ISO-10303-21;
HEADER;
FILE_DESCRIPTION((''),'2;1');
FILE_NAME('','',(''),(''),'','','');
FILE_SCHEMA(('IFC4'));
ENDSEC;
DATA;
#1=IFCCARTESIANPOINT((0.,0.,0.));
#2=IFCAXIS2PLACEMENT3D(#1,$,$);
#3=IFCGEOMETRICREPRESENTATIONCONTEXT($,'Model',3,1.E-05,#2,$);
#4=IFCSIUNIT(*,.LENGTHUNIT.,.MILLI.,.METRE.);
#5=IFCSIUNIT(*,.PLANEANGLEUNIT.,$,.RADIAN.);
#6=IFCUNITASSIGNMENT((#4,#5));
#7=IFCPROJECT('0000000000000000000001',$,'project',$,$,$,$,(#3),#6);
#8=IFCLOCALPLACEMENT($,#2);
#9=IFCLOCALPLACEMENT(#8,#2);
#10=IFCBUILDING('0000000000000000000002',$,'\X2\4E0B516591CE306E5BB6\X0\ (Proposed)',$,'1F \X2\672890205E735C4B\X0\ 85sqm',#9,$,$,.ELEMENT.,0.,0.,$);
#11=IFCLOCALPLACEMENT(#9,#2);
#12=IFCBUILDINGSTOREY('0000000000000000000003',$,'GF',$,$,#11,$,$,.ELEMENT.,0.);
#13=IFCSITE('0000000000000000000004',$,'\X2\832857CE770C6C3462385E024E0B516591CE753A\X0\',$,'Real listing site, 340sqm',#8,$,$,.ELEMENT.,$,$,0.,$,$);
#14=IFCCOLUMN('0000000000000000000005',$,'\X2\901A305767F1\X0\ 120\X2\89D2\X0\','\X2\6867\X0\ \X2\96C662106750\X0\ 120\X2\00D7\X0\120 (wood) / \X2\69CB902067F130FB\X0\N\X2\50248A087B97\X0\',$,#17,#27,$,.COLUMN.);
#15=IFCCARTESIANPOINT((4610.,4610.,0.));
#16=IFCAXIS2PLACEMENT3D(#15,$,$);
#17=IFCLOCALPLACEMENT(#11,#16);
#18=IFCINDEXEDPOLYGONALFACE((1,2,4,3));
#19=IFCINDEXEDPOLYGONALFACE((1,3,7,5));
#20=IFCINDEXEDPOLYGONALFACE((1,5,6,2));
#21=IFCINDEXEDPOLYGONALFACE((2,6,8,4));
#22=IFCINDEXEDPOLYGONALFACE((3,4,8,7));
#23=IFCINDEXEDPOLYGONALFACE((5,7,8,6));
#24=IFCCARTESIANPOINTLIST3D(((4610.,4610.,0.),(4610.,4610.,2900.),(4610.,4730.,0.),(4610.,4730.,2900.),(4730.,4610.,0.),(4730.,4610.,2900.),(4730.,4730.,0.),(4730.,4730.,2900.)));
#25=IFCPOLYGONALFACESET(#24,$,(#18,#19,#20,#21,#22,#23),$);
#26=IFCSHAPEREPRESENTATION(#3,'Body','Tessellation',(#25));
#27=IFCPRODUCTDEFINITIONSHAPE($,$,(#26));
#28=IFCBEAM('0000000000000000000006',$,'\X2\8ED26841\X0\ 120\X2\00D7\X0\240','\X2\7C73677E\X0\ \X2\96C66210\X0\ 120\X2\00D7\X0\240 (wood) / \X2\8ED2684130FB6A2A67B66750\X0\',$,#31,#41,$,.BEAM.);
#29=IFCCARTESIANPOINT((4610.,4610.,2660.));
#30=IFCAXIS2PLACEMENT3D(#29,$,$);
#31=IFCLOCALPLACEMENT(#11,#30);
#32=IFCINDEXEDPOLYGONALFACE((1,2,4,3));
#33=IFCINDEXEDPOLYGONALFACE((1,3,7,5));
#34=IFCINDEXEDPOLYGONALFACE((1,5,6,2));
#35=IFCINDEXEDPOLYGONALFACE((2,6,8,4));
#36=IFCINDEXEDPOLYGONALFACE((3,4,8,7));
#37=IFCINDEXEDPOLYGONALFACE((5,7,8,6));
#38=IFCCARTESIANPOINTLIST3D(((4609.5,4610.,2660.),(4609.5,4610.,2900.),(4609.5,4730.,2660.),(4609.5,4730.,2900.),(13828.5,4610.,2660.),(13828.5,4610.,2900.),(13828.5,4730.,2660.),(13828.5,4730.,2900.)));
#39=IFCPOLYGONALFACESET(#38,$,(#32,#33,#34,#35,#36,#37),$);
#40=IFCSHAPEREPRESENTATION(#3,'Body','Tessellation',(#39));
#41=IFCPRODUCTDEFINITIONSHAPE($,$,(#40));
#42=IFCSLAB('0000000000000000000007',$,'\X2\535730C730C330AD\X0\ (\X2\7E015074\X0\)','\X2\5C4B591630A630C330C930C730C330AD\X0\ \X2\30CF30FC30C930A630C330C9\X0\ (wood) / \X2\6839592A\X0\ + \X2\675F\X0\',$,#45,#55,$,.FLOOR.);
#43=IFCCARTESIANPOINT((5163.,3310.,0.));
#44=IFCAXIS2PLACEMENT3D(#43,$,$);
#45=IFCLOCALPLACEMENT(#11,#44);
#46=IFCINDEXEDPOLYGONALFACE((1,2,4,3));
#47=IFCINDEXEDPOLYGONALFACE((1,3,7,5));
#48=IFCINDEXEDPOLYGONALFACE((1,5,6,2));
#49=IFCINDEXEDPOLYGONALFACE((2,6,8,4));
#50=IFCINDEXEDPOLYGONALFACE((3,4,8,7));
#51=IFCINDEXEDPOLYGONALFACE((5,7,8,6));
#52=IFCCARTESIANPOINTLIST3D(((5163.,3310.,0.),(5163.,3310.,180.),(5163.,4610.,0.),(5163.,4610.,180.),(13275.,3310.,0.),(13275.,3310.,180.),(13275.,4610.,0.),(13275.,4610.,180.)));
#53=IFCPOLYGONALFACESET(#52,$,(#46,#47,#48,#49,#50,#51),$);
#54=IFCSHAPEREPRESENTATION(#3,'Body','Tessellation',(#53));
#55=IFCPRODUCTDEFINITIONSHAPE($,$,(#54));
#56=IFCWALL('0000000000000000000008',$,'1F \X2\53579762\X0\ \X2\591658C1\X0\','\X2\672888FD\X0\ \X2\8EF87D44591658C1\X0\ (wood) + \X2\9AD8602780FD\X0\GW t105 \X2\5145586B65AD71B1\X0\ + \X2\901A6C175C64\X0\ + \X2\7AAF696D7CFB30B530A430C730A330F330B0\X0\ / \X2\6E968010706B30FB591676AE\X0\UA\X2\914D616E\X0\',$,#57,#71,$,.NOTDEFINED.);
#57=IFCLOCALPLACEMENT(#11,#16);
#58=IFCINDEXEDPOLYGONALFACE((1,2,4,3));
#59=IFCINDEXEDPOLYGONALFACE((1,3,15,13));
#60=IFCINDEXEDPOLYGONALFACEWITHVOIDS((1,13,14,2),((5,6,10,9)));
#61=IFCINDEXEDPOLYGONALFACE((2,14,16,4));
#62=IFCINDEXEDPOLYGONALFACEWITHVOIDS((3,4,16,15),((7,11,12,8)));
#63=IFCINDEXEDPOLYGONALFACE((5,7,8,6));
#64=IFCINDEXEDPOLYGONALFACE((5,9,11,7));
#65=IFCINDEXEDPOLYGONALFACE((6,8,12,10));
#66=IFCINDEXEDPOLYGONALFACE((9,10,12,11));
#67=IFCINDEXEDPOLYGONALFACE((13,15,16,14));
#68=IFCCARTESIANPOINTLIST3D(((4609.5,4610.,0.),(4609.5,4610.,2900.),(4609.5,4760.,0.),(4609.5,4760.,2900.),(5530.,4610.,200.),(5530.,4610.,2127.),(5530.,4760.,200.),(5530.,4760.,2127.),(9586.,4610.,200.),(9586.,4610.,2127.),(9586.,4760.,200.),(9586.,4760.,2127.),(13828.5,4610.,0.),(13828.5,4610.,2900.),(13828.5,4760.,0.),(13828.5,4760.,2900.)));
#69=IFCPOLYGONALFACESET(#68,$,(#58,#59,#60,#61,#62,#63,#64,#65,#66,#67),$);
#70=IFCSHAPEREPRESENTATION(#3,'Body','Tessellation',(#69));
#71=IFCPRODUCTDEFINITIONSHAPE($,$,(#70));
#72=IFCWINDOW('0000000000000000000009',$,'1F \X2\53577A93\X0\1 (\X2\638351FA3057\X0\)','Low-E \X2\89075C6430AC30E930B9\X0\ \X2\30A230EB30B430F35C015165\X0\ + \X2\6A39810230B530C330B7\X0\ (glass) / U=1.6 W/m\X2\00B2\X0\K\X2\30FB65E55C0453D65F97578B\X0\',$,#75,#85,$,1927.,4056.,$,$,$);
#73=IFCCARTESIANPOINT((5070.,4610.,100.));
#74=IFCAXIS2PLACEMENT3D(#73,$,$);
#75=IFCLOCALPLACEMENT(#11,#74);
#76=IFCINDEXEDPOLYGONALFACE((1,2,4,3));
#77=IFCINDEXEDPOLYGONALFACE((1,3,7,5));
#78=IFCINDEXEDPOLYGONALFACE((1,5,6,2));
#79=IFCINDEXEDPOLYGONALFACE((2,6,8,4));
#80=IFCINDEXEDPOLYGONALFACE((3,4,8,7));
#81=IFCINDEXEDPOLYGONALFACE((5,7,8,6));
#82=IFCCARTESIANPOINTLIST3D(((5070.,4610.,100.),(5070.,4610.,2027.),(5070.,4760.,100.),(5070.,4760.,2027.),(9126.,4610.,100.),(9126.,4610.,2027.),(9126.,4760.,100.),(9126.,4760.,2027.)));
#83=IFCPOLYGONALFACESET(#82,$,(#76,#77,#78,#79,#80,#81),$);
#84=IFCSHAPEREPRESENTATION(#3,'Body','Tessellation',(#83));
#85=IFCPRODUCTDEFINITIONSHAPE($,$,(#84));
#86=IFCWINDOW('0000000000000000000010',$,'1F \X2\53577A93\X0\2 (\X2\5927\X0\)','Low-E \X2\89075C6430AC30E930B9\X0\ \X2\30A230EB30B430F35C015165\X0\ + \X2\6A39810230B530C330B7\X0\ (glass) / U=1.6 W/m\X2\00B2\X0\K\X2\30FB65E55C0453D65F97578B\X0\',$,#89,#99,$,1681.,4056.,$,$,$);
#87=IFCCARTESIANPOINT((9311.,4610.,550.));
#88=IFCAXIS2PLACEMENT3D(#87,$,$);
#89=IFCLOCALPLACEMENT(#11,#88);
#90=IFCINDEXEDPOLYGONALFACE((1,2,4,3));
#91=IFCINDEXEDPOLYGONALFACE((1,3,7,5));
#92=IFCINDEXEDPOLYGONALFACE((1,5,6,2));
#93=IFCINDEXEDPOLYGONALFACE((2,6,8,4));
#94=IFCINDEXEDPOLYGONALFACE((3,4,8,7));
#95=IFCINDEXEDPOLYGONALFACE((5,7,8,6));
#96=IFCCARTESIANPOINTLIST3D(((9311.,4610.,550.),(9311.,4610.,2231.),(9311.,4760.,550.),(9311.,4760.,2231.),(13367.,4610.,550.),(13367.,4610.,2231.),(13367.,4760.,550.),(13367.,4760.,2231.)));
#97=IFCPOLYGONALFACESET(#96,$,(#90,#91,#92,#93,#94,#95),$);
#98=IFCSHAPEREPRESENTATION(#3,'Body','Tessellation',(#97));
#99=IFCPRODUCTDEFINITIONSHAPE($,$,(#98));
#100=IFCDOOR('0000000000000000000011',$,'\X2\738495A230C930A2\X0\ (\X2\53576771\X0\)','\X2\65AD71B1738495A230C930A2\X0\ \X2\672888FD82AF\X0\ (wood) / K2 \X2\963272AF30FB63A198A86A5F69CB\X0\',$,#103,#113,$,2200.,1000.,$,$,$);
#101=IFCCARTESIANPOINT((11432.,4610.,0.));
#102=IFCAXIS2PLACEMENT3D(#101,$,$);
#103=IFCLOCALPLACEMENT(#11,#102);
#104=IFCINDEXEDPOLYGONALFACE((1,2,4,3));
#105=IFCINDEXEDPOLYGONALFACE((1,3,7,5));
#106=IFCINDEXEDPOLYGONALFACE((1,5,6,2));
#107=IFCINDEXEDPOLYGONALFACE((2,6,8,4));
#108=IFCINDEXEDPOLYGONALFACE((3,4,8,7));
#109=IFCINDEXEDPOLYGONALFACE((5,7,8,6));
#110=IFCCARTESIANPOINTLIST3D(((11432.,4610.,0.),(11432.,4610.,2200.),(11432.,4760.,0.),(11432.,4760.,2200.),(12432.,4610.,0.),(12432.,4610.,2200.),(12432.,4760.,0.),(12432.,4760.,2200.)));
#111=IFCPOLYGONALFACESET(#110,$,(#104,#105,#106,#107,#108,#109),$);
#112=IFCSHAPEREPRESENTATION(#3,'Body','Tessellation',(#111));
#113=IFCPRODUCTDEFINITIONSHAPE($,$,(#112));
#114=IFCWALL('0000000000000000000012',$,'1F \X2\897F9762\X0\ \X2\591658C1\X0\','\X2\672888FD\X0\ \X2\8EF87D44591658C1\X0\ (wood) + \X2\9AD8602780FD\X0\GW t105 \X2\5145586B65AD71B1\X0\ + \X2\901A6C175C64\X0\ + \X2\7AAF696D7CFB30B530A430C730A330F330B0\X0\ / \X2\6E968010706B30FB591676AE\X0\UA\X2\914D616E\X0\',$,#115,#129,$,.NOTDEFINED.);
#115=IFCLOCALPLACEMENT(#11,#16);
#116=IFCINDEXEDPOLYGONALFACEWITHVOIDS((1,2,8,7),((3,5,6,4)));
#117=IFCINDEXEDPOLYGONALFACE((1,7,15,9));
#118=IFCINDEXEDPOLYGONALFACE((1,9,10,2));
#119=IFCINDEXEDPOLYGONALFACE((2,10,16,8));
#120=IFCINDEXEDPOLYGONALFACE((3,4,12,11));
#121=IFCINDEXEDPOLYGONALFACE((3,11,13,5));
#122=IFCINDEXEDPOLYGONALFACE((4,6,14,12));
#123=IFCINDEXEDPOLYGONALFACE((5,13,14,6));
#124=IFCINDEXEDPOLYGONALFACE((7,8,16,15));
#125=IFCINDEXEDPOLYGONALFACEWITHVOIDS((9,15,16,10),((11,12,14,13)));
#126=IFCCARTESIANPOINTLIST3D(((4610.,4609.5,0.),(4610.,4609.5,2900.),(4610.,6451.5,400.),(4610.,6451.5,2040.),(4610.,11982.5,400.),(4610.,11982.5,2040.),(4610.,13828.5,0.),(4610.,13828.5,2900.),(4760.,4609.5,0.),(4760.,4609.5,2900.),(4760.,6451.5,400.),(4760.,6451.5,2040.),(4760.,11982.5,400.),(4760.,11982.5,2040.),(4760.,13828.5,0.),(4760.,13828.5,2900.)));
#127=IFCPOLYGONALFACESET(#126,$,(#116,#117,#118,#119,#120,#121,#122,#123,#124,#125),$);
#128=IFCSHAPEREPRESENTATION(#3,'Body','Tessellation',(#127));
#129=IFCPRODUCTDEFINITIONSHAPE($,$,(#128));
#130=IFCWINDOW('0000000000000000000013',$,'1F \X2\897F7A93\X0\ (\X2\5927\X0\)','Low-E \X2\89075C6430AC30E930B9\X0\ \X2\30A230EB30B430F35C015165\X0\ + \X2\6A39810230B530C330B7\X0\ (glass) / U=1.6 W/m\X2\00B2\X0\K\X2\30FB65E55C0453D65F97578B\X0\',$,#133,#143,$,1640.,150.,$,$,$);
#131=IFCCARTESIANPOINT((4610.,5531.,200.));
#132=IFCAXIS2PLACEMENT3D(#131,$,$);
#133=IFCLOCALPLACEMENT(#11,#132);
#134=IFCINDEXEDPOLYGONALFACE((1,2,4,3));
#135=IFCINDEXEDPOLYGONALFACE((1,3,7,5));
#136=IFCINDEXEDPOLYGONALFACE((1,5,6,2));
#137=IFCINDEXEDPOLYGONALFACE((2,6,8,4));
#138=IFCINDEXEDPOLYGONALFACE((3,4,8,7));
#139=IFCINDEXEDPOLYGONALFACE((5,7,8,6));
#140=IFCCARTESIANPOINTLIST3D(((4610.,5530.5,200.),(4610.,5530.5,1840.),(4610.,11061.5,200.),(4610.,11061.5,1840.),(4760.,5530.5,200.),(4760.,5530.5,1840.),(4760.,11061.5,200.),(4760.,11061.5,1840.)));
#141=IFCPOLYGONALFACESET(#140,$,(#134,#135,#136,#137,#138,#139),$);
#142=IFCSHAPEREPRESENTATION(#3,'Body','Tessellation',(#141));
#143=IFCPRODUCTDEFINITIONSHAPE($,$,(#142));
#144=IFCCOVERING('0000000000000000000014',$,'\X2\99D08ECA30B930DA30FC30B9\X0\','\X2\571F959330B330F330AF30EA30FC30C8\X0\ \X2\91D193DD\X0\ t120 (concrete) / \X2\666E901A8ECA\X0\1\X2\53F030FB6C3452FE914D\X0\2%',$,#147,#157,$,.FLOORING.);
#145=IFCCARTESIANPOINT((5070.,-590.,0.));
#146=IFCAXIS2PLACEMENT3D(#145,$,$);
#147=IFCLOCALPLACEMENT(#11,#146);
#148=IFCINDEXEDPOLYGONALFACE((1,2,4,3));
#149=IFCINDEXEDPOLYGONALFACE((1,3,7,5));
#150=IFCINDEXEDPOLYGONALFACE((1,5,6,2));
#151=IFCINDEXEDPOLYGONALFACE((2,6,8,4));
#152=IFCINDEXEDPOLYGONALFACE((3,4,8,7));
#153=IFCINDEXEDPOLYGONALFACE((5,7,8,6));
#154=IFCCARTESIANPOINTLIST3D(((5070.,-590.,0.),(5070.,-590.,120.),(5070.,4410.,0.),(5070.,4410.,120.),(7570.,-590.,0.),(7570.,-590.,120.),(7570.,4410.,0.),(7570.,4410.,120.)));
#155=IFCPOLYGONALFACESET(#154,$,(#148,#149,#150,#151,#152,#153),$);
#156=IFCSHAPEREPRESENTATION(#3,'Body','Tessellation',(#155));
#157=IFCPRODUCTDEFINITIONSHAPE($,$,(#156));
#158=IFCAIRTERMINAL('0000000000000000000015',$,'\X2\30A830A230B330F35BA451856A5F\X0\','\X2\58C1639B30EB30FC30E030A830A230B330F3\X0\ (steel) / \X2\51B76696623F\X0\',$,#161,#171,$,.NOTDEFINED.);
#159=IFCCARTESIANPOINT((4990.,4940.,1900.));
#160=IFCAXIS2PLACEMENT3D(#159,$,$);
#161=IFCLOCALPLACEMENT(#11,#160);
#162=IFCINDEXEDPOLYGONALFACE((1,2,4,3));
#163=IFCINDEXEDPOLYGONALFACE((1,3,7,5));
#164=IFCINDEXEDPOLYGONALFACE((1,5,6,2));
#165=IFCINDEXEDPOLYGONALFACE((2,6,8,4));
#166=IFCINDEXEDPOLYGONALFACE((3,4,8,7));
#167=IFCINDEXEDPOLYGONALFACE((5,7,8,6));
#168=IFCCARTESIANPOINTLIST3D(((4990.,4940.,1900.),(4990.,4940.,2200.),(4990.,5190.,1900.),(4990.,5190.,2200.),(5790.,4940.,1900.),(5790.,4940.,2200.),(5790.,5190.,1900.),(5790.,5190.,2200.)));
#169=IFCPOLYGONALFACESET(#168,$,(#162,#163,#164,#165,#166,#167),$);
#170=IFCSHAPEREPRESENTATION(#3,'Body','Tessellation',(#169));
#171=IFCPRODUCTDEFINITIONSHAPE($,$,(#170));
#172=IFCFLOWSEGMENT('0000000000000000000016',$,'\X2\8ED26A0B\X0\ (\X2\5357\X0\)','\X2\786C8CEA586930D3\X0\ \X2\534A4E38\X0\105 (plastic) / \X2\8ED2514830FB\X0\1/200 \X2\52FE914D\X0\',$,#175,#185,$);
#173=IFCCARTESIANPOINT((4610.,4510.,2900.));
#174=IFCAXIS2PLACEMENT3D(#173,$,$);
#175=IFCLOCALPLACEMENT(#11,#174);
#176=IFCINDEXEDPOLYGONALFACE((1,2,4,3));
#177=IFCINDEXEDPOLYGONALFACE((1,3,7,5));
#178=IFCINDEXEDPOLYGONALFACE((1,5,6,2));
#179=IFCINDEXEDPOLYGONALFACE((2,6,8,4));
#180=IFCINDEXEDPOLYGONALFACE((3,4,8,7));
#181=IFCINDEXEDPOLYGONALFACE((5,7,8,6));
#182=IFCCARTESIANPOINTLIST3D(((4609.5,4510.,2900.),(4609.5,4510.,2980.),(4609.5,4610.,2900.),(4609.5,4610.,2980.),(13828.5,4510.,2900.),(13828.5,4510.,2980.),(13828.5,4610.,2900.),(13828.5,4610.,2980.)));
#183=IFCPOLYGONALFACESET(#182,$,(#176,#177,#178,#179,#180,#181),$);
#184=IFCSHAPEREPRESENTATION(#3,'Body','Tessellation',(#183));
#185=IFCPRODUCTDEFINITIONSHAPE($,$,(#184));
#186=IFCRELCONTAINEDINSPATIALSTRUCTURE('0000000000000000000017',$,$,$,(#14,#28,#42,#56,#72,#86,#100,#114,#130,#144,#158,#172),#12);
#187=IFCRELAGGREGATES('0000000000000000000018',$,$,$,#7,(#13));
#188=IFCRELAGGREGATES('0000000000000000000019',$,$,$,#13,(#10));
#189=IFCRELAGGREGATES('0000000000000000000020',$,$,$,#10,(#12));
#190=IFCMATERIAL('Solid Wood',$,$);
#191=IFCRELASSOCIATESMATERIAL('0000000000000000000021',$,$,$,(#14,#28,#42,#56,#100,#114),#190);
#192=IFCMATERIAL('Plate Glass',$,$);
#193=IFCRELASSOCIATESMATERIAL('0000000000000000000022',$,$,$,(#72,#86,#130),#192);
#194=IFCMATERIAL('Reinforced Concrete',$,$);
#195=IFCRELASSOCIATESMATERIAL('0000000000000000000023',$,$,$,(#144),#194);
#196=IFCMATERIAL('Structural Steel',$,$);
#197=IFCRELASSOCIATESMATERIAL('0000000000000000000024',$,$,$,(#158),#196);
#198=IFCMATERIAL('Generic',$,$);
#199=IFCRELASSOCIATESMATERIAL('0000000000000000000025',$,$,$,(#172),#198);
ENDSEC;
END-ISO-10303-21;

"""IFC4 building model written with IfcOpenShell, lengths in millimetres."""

from ifc_helpers import new_model, si_unit, frame, frame_2d, origin, place, context, project, spatial, rectangle, extrude, material, element, fill, save


model = new_model("IFC4")

# Units and contexts
model_context = context("Model", 3, precision=1e-05, world=origin())
ifc_project = project(units=[si_unit("LENGTHUNIT", "METRE", prefix="MILLI"), si_unit("PLANEANGLEUNIT", "RADIAN")], contexts=[model_context])

# Site, building, storey
site_placement = place(None, origin())
site = spatial("IfcSite", under=ifc_project, at=site_placement, Name="茨城県水戸市下入野町", ObjectType="Real listing site, 340sqm", CompositionType="ELEMENT", RefElevation=0.0)
building_placement = place(site_placement, origin())
building = spatial("IfcBuilding", under=site, at=building_placement, Name="下入野の家 (Proposed)", ObjectType="1F 木造平屋 85sqm", CompositionType="ELEMENT", ElevationOfRefHeight=0.0, ElevationOfTerrain=0.0)
storey_placement = place(building_placement, origin())
storey = spatial("IfcBuildingStorey", under=building, at=storey_placement, Name="GF", CompositionType="ELEMENT", Elevation=0.0)

# Column
ifc_material_1 = material(Name="Solid Wood")
column_1_placement = place(storey_placement, frame((4610.0, 4610.0, 0.0)))
element("IfcColumn", 1, at=column_1_placement, inside=storey, material=ifc_material_1, Name="通し柱 120角", Description="桧 集成材 120×120 (wood) / 構造柱・N値計算", PredefinedType="COLUMN", context=model_context, shape_type="SweptSolid", body=[
    extrude(rectangle(XDim=120.0, YDim=120.0, at=frame_2d((60.0, 60.0))), frame((4610.0, 4610.0, 0.0)), (0.0, 0.0, 1.0), 2900.0),
])

# Beam
beam_1_placement = place(storey_placement, frame((4610.0, 4610.0, 2660.0)))
element("IfcBeam", 2, at=beam_1_placement, inside=storey, material=ifc_material_1, Name="軒桁 120×240", Description="米松 集成 120×240 (wood) / 軒桁・横架材", PredefinedType="BEAM", context=model_context, shape_type="SweptSolid", body=[
    extrude(rectangle(XDim=9219.0, YDim=120.0, at=frame_2d((4609.0, 60.0))), frame((4610.0, 4610.0, 2660.0)), (0.0, 0.0, 1.0), 240.0),
])

# Slab
ifc_material_2 = material(Name="Reinforced Concrete")
slab_1_placement = place(storey_placement, frame((5163.0, 3310.0, 0.0)))
element("IfcSlab", 3, at=slab_1_placement, inside=storey, material=ifc_material_1, Name="南デッキ (縁側)", Description="屋外ウッドデッキ ハードウッド (wood) / 根太 + 束", PredefinedType="FLOOR", context=model_context, shape_type="SweptSolid", body=[
    extrude(rectangle(XDim=8112.0, YDim=1300.0, at=frame_2d((4056.0, 650.0))), frame((5163.0, 3310.0, 0.0)), (0.0, 0.0, 1.0), 180.0),
])

# Wall, openings, windows, door
wall_1_placement = place(storey_placement, frame((4610.0, 4610.0, 0.0)))
wall_1 = element("IfcWall", 4, at=wall_1_placement, inside=storey, material=ifc_material_1, Name="1F 南面 外壁", Description="木製 軸組外壁 (wood) + 高性能GW t105 充填断熱 + 通気層 + 窯業系サイディング / 準耐火・外皮UA配慮", PredefinedType="NOTDEFINED", context=model_context, shape_type="SweptSolid", body=[
    extrude(rectangle(XDim=9219.0, YDim=150.0, at=frame_2d((4609.0, 75.0))), frame((4610.0, 4610.0, 0.0)), (0.0, 0.0, 1.0), 2900.0),
])
opening_1_placement = place(storey_placement, frame((5070.0, 4610.0, 100.0)))
opening_1 = element("IfcOpeningElement", 5, at=opening_1_placement, cuts=wall_1, PredefinedType="NOTDEFINED", context=model_context, shape_type="SweptSolid", body=[
    extrude(rectangle(XDim=4056.0, YDim=150.0, at=frame_2d((2028.0, 75.0))), frame((5070.0, 4610.0, 100.0)), (0.0, 0.0, 1.0), 1927.0),
])
opening_2_placement = place(storey_placement, frame((9311.0, 4610.0, 550.0)))
opening_2 = element("IfcOpeningElement", 6, at=opening_2_placement, cuts=wall_1, PredefinedType="NOTDEFINED", context=model_context, shape_type="SweptSolid", body=[
    extrude(rectangle(XDim=4056.0, YDim=150.0, at=frame_2d((2028.0, 75.0))), frame((9311.0, 4610.0, 550.0)), (0.0, 0.0, 1.0), 1681.0),
])
opening_3_placement = place(storey_placement, frame((11432.0, 4610.0, 0.0)))
opening_3 = element("IfcOpeningElement", 7, at=opening_3_placement, cuts=wall_1, PredefinedType="NOTDEFINED", context=model_context, shape_type="SweptSolid", body=[
    extrude(rectangle(XDim=1000.0, YDim=150.0, at=frame_2d((500.0, 75.0))), frame((11432.0, 4610.0, 0.0)), (0.0, 0.0, 1.0), 2200.0),
])
ifc_material_3 = material(Name="Plate Glass")
window_1_placement = place(storey_placement, frame((5070.0, 4610.0, 100.0)))
window_1 = element("IfcWindow", 8, at=window_1_placement, inside=storey, material=ifc_material_3, Name="1F 南窓1 (掃出し)", Description="Low-E 複層ガラス アルゴン封入 + 樹脂サッシ (glass) / U=1.6 W/m²K・日射取得型", OverallHeight=1927.0, OverallWidth=4056.0, context=model_context, shape_type="SweptSolid", body=[
    extrude(rectangle(XDim=4056.0, YDim=150.0, at=frame_2d((2028.0, 75.0))), frame((5070.0, 4610.0, 100.0)), (0.0, 0.0, 1.0), 1927.0),
])
fill(opening_1, window_1)
window_2_placement = place(storey_placement, frame((9311.0, 4610.0, 550.0)))
window_2 = element("IfcWindow", 9, at=window_2_placement, inside=storey, material=ifc_material_3, Name="1F 南窓2 (大)", Description="Low-E 複層ガラス アルゴン封入 + 樹脂サッシ (glass) / U=1.6 W/m²K・日射取得型", OverallHeight=1681.0, OverallWidth=4056.0, context=model_context, shape_type="SweptSolid", body=[
    extrude(rectangle(XDim=4056.0, YDim=150.0, at=frame_2d((2028.0, 75.0))), frame((9311.0, 4610.0, 550.0)), (0.0, 0.0, 1.0), 1681.0),
])
fill(opening_2, window_2)
door_placement = place(storey_placement, frame((11432.0, 4610.0, 0.0)))
door = element("IfcDoor", 10, at=door_placement, inside=storey, material=ifc_material_1, Name="玄関ドア (南東)", Description="断熱玄関ドア 木製芯 (wood) / K2 防犯・採風機構", OverallHeight=2200.0, OverallWidth=1000.0, context=model_context, shape_type="SweptSolid", body=[
    extrude(rectangle(XDim=1000.0, YDim=150.0, at=frame_2d((500.0, 75.0))), frame((11432.0, 4610.0, 0.0)), (0.0, 0.0, 1.0), 2200.0),
])
fill(opening_3, door)

# Wall, opening, window
wall_2_placement = place(storey_placement, frame((4610.0, 4610.0, 0.0)))
wall_2 = element("IfcWall", 11, at=wall_2_placement, inside=storey, material=ifc_material_1, Name="1F 西面 外壁", Description="木製 軸組外壁 (wood) + 高性能GW t105 充填断熱 + 通気層 + 窯業系サイディング / 準耐火・外皮UA配慮", PredefinedType="NOTDEFINED", context=model_context, shape_type="SweptSolid", body=[
    extrude(rectangle(XDim=150.0, YDim=9219.0, at=frame_2d((75.0, 4609.0))), frame((4610.0, 4610.0, 0.0)), (0.0, 0.0, 1.0), 2900.0),
])
opening_4_placement = place(storey_placement, frame((4610.0, 5531.0, 200.0)))
opening_4 = element("IfcOpeningElement", 12, at=opening_4_placement, cuts=wall_2, PredefinedType="NOTDEFINED", context=model_context, shape_type="SweptSolid", body=[
    extrude(rectangle(XDim=150.0, YDim=5531.0, at=frame_2d((75.0, 2765.0))), frame((4610.0, 5531.0, 200.0)), (0.0, 0.0, 1.0), 1640.0),
])
window_3_placement = place(storey_placement, frame((4610.0, 5531.0, 200.0)))
window_3 = element("IfcWindow", 13, at=window_3_placement, inside=storey, material=ifc_material_3, Name="1F 西窓 (大)", Description="Low-E 複層ガラス アルゴン封入 + 樹脂サッシ (glass) / U=1.6 W/m²K・日射取得型", OverallHeight=1640.0, OverallWidth=150.0, context=model_context, shape_type="SweptSolid", body=[
    extrude(rectangle(XDim=150.0, YDim=5531.0, at=frame_2d((75.0, 2765.0))), frame((4610.0, 5531.0, 200.0)), (0.0, 0.0, 1.0), 1640.0),
])
fill(opening_4, window_3)

# Shared definitions
ifc_material_4 = material(Name="Structural Steel")

# Covering
ifc_material_5 = material(Name="Generic")
covering_1_placement = place(storey_placement, frame((5070.0, -590.0, 0.0)))
element("IfcCovering", 14, at=covering_1_placement, inside=storey, material=ifc_material_2, Name="駐車スペース", Description="土間コンクリート 金鏝 t120 (concrete) / 普通車1台・水勾配2%", PredefinedType="FLOORING", context=model_context, shape_type="SweptSolid", body=[
    extrude(rectangle(XDim=2500.0, YDim=5000.0, at=frame_2d((1250.0, 2500.0))), frame((5070.0, -590.0, 0.0)), (0.0, 0.0, 1.0), 120.0),
])

# Air terminal
air_terminal_placement = place(storey_placement, frame((4990.0, 4940.0, 1900.0)))
element("IfcAirTerminal", 15, at=air_terminal_placement, inside=storey, material=ifc_material_4, Name="エアコン室内機", Description="壁掛ルームエアコン (steel) / 冷暖房", PredefinedType="NOTDEFINED", context=model_context, shape_type="SweptSolid", body=[
    extrude(rectangle(XDim=800.0, YDim=250.0, at=frame_2d((400.0, 125.0))), frame((4990.0, 4940.0, 1900.0)), (0.0, 0.0, 1.0), 300.0),
])

# Flow segment
flow_segment_1_placement = place(storey_placement, frame((4610.0, 4510.0, 2900.0)))
element("IfcFlowSegment", 16, at=flow_segment_1_placement, inside=storey, material=ifc_material_5, Name="軒樋 (南)", Description="硬質塩ビ 半丸105 (plastic) / 軒先・1/200 勾配", context=model_context, shape_type="SweptSolid", body=[
    extrude(rectangle(XDim=9219.0, YDim=100.0, at=frame_2d((4609.0, 50.0))), frame((4610.0, 4510.0, 2900.0)), (0.0, 0.0, 1.0), 80.0),
])

save(model, "model.ifc")
